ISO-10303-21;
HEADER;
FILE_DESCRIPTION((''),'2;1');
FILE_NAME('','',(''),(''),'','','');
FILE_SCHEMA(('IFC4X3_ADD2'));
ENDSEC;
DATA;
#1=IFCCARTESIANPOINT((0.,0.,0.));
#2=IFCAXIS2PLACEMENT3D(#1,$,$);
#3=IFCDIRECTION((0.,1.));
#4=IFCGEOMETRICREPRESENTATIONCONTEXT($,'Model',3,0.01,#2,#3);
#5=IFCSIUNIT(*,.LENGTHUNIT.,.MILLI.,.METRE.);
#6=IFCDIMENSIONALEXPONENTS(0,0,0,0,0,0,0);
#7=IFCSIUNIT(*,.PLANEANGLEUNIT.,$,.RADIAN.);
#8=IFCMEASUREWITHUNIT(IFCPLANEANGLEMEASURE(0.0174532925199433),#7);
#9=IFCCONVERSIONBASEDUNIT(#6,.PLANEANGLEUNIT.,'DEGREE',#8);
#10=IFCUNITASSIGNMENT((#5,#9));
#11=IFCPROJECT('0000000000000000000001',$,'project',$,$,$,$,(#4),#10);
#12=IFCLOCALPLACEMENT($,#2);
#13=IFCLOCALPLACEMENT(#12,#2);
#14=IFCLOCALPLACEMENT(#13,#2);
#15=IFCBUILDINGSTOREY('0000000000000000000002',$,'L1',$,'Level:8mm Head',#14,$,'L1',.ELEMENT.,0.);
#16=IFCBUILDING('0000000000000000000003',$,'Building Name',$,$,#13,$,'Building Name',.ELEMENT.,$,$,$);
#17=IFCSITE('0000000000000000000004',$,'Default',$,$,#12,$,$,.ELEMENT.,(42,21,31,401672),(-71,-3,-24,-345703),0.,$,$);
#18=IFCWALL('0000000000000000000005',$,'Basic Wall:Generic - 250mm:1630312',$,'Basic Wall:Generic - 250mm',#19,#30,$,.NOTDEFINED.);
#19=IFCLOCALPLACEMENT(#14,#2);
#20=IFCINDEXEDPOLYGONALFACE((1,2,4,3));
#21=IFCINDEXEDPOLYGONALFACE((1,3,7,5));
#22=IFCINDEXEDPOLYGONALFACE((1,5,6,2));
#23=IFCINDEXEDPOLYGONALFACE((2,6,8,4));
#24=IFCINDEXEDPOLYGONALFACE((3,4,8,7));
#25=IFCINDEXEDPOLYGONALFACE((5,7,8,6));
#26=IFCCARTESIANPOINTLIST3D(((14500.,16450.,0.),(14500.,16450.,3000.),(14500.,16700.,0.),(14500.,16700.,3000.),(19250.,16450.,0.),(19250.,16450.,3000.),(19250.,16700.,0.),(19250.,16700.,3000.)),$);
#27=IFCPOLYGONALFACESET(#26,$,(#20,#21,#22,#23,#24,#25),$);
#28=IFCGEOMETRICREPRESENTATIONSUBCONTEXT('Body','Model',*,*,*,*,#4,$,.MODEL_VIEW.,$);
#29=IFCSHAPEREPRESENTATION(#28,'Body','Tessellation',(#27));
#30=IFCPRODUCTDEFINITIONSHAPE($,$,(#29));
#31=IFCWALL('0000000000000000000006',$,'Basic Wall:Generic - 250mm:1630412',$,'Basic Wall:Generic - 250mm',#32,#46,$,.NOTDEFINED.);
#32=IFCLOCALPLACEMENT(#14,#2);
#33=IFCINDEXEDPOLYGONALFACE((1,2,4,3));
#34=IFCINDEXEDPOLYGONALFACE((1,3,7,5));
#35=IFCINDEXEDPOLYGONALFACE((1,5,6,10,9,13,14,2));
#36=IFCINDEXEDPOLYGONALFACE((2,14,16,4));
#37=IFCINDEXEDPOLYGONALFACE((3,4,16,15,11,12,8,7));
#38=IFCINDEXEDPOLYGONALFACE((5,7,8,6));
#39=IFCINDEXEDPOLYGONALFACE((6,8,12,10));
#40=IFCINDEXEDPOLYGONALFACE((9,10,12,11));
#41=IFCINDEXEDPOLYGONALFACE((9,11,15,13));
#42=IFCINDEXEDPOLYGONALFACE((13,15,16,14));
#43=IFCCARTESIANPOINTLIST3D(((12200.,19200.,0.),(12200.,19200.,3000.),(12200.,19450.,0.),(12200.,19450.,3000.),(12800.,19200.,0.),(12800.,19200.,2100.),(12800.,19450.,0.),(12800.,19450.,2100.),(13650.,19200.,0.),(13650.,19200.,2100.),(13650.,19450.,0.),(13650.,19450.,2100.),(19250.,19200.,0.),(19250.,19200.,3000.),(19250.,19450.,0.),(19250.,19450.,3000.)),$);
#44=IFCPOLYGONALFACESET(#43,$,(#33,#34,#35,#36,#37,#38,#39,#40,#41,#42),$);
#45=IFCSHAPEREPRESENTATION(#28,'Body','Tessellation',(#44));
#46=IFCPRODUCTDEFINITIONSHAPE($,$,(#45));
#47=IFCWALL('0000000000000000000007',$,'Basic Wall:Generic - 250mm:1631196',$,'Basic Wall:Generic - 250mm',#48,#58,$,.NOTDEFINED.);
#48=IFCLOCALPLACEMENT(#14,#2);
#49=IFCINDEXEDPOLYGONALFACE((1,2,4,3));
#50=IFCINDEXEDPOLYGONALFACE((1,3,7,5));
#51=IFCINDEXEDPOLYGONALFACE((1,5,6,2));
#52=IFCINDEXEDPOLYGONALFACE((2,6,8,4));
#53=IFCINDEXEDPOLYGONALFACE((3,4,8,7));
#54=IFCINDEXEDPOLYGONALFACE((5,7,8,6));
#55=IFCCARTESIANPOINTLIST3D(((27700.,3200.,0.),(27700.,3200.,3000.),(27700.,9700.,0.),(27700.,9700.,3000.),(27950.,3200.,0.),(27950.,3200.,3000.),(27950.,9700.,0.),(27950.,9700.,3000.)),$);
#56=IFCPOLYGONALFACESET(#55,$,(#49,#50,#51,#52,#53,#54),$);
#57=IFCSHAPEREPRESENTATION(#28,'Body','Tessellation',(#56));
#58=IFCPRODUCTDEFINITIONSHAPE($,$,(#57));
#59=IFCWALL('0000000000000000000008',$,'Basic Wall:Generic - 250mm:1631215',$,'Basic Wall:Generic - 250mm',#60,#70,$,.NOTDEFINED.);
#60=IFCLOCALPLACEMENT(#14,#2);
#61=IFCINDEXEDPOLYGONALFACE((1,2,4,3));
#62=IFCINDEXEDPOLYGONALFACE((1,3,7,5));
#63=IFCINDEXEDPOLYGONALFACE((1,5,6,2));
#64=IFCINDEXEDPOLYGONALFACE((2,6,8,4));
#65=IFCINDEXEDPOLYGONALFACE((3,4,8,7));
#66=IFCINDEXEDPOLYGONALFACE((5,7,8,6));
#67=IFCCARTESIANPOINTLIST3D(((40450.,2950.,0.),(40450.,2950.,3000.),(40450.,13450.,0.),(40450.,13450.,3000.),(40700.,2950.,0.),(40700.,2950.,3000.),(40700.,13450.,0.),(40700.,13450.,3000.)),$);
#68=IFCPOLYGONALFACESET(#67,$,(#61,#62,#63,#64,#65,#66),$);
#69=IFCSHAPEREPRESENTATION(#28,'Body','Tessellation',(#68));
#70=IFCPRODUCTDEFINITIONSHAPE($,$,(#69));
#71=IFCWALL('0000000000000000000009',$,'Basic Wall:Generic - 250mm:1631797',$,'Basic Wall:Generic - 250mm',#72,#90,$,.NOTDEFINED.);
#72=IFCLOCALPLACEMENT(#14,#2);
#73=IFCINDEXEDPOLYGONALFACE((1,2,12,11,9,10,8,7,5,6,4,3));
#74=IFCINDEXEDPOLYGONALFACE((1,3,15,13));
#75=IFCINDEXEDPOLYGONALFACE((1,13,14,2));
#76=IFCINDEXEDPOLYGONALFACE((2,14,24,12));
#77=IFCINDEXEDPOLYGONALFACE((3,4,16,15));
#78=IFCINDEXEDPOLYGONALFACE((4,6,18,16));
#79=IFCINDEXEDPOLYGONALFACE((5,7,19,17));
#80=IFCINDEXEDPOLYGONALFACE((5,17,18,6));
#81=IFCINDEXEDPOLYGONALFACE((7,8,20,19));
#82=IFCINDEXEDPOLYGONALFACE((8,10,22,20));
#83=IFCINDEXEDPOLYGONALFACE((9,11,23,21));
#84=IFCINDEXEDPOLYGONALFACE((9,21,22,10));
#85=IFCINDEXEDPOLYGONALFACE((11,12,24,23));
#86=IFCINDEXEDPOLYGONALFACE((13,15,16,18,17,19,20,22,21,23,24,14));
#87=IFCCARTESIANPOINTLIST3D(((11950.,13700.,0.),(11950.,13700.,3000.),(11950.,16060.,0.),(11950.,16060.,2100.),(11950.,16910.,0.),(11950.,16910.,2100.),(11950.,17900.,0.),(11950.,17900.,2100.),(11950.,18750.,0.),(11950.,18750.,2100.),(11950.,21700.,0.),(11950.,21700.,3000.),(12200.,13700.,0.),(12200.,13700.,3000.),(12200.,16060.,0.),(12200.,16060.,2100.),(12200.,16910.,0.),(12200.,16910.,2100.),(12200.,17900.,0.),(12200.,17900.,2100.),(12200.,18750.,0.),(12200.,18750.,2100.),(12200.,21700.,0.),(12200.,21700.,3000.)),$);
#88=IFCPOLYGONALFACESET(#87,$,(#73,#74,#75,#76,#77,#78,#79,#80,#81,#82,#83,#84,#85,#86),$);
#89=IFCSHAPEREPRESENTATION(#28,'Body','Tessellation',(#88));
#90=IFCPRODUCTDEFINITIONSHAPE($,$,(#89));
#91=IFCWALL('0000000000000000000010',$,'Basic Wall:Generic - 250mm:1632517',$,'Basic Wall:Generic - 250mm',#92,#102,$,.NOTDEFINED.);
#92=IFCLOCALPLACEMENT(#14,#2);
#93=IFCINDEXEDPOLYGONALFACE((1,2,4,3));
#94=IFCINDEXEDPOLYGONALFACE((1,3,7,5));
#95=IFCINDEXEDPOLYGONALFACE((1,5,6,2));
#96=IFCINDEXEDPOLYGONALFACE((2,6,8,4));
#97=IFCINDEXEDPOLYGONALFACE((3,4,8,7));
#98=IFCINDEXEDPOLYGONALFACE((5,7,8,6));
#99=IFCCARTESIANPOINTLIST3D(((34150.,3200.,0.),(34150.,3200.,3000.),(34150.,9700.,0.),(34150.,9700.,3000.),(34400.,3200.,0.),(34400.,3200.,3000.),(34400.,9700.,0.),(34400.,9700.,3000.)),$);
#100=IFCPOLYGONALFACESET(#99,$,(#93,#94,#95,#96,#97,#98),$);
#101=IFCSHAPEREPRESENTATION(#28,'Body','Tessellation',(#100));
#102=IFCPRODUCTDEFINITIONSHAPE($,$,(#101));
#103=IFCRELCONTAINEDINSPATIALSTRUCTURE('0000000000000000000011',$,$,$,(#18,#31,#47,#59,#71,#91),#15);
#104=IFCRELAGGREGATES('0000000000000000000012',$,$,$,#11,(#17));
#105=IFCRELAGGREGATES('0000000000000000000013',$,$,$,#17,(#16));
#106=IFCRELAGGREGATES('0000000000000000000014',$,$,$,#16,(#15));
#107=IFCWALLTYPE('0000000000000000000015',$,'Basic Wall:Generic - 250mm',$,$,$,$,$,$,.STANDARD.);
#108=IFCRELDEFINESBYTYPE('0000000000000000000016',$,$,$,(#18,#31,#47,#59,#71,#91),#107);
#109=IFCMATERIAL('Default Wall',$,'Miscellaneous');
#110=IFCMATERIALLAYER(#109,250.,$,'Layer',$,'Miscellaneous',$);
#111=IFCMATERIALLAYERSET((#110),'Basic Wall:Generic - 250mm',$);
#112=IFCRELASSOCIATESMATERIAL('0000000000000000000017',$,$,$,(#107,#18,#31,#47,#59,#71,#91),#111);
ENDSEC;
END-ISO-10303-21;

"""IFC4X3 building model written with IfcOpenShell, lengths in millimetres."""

from ifc_helpers import new_model, entity, si_unit, converted_unit, direction, frame, frame_2d, origin, place, context, subcontext, project, spatial, rectangle, extrude, material, layer, layer_set, type_object, element, save


model = new_model("IFC4X3")

# Units and contexts
model_context = context("Model", 3, precision=0.01, world=origin(), true_north=direction((0.0, 1.0)))
body_context = subcontext(model_context, "Body", "Model", "MODEL_VIEW")
ifc_project = project(units=[si_unit("LENGTHUNIT", "METRE", prefix="MILLI"), converted_unit("PLANEANGLEUNIT", "DEGREE", entity("IfcPlaneAngleMeasure", 0.0174532925199433), si_unit("PLANEANGLEUNIT", "RADIAN"), dimensions=[0, 0, 0, 0, 0, 0, 0])], contexts=[model_context])

# Site, building, storey
site_placement = place(None, origin())
site = spatial("IfcSite", under=ifc_project, at=site_placement, Name="Default", CompositionType="ELEMENT", RefLatitude=(42, 21, 31, 401672), RefLongitude=(-71, -3, -24, -345703), RefElevation=0.0)
building_placement = place(site_placement, origin())
building = spatial("IfcBuilding", under=site, at=building_placement, Name="Building Name", LongName="Building Name", CompositionType="ELEMENT")
storey_placement = place(building_placement, origin())
storey = spatial("IfcBuildingStorey", under=building, at=storey_placement, Name="L1", ObjectType="Level:8mm Head", LongName="L1", CompositionType="ELEMENT", Elevation=0.0)

# Shared definitions
ifc_material = material(Name="Default Wall", Category="Miscellaneous")
ifc_layer = layer(ifc_material, 250.0, Name="Layer", Category="Miscellaneous")
ifc_layer_set = layer_set([ifc_layer], Name="Basic Wall:Generic - 250mm")
wall_type = type_object("IfcWallType", Name="Basic Wall:Generic - 250mm", PredefinedType="STANDARD", material=ifc_layer_set)

# Wall
wall_1_placement = place(storey_placement, frame((14500.0, 16575.0, 0.0)))
element("IfcWall", 1, at=wall_1_placement, inside=storey, type_object=wall_type, material=ifc_layer_set, Name="Basic Wall:Generic - 250mm:1630312", ObjectType="Basic Wall:Generic - 250mm", PredefinedType="NOTDEFINED", context=body_context, shape_type="SweptSolid", body=[
    extrude(rectangle(XDim=4750.0, YDim=250.0, at=frame_2d((2375.0, 0.0), x_axis=(-1.0, 0.0))), origin(), (0.0, 0.0, 1.0), 3000.0),
])

# Wall, opening
wall_2_placement = place(storey_placement, frame((12200.0, 19325.0, 0.0)))
wall_2 = element("IfcWall", 2, at=wall_2_placement, inside=storey, type_object=wall_type, material=ifc_layer_set, Name="Basic Wall:Generic - 250mm:1630412", ObjectType="Basic Wall:Generic - 250mm", PredefinedType="NOTDEFINED", context=body_context, shape_type="SweptSolid", body=[
    extrude(rectangle(XDim=7050.0, YDim=250.0, at=frame_2d((3525.0, 0.0), x_axis=(-1.0, 0.0))), origin(), (0.0, 0.0, 1.0), 3000.0),
])
opening_1_placement = place(wall_2_placement, frame((600.0, -125.0, 0.0)))
element("IfcOpeningElement", 3, at=opening_1_placement, cuts=wall_2, PredefinedType="OPENING", context=body_context, shape_type="SweptSolid", body=[
    extrude(rectangle(XDim=2100.0, YDim=850.0, at=frame_2d((1050.0, 425.0), x_axis=(1.0, 0.0))), frame((0.0, 0.0, 0.0), z_axis=(0.0, 1.0, 0.0), x_axis=(0.0, 0.0, 1.0)), (0.0, 0.0, 1.0), 250.0),
])

# Walls
wall_3_placement = place(storey_placement, frame((27825.0, 3200.0, 0.0), z_axis=(0.0, 0.0, 1.0), x_axis=(0.0, 1.0, 0.0)))
element("IfcWall", 4, at=wall_3_placement, inside=storey, type_object=wall_type, material=ifc_layer_set, Name="Basic Wall:Generic - 250mm:1631196", ObjectType="Basic Wall:Generic - 250mm", PredefinedType="NOTDEFINED", context=body_context, shape_type="SweptSolid", body=[
    extrude(rectangle(XDim=6500.0, YDim=250.0, at=frame_2d((3250.0, 0.0), x_axis=(-1.0, 0.0))), origin(), (0.0, 0.0, 1.0), 3000.0),
])
wall_4_placement = place(storey_placement, frame((40575.0, 2950.0, 0.0), z_axis=(0.0, 0.0, 1.0), x_axis=(0.0, 1.0, 0.0)))
element("IfcWall", 5, at=wall_4_placement, inside=storey, type_object=wall_type, material=ifc_layer_set, Name="Basic Wall:Generic - 250mm:1631215", ObjectType="Basic Wall:Generic - 250mm", PredefinedType="NOTDEFINED", context=body_context, shape_type="SweptSolid", body=[
    extrude(rectangle(XDim=10500.0, YDim=250.0, at=frame_2d((5250.0, 0.0), x_axis=(-1.0, 0.0))), origin(), (0.0, 0.0, 1.0), 3000.0),
])

# Wall, openings
wall_5_placement = place(storey_placement, frame((12075.0, 13700.0, 0.0), z_axis=(0.0, 0.0, 1.0), x_axis=(0.0, 1.0, 0.0)))
wall_5 = element("IfcWall", 6, at=wall_5_placement, inside=storey, type_object=wall_type, material=ifc_layer_set, Name="Basic Wall:Generic - 250mm:1631797", ObjectType="Basic Wall:Generic - 250mm", PredefinedType="NOTDEFINED", context=body_context, shape_type="SweptSolid", body=[
    extrude(rectangle(XDim=8000.0, YDim=250.0, at=frame_2d((4000.0, 0.0), x_axis=(-1.0, 0.0))), origin(), (0.0, 0.0, 1.0), 3000.0),
])
opening_2_placement = place(wall_5_placement, frame((4200.0, -125.0, 0.0)))
element("IfcOpeningElement", 7, at=opening_2_placement, cuts=wall_5, PredefinedType="OPENING", context=body_context, shape_type="SweptSolid", body=[
    extrude(rectangle(XDim=2100.0, YDim=850.0, at=frame_2d((1050.0, 425.0), x_axis=(1.0, 0.0))), frame((0.0, 0.0, 0.0), z_axis=(0.0, 1.0, 0.0), x_axis=(0.0, 0.0, 1.0)), (0.0, 0.0, 1.0), 250.0),
])
opening_3_placement = place(wall_5_placement, frame((2360.0, -125.0, 0.0)))
element("IfcOpeningElement", 8, at=opening_3_placement, cuts=wall_5, PredefinedType="OPENING", context=body_context, shape_type="SweptSolid", body=[
    extrude(rectangle(XDim=2100.0, YDim=850.0, at=frame_2d((1050.0, 425.0), x_axis=(1.0, 0.0))), frame((0.0, 0.0, 0.0), z_axis=(0.0, 1.0, 0.0), x_axis=(0.0, 0.0, 1.0)), (0.0, 0.0, 1.0), 250.0),
])

# Wall
wall_6_placement = place(storey_placement, frame((34275.0, 9700.0, 0.0), z_axis=(0.0, 0.0, 1.0), x_axis=(0.0, -1.0, 0.0)))
element("IfcWall", 9, at=wall_6_placement, inside=storey, type_object=wall_type, material=ifc_layer_set, Name="Basic Wall:Generic - 250mm:1632517", ObjectType="Basic Wall:Generic - 250mm", PredefinedType="NOTDEFINED", context=body_context, shape_type="SweptSolid", body=[
    extrude(rectangle(XDim=6500.0, YDim=250.0, at=frame_2d((3250.0, 0.0), x_axis=(-1.0, 0.0))), origin(), (0.0, 0.0, 1.0), 3000.0),
])

save(model, "model.ifc")
